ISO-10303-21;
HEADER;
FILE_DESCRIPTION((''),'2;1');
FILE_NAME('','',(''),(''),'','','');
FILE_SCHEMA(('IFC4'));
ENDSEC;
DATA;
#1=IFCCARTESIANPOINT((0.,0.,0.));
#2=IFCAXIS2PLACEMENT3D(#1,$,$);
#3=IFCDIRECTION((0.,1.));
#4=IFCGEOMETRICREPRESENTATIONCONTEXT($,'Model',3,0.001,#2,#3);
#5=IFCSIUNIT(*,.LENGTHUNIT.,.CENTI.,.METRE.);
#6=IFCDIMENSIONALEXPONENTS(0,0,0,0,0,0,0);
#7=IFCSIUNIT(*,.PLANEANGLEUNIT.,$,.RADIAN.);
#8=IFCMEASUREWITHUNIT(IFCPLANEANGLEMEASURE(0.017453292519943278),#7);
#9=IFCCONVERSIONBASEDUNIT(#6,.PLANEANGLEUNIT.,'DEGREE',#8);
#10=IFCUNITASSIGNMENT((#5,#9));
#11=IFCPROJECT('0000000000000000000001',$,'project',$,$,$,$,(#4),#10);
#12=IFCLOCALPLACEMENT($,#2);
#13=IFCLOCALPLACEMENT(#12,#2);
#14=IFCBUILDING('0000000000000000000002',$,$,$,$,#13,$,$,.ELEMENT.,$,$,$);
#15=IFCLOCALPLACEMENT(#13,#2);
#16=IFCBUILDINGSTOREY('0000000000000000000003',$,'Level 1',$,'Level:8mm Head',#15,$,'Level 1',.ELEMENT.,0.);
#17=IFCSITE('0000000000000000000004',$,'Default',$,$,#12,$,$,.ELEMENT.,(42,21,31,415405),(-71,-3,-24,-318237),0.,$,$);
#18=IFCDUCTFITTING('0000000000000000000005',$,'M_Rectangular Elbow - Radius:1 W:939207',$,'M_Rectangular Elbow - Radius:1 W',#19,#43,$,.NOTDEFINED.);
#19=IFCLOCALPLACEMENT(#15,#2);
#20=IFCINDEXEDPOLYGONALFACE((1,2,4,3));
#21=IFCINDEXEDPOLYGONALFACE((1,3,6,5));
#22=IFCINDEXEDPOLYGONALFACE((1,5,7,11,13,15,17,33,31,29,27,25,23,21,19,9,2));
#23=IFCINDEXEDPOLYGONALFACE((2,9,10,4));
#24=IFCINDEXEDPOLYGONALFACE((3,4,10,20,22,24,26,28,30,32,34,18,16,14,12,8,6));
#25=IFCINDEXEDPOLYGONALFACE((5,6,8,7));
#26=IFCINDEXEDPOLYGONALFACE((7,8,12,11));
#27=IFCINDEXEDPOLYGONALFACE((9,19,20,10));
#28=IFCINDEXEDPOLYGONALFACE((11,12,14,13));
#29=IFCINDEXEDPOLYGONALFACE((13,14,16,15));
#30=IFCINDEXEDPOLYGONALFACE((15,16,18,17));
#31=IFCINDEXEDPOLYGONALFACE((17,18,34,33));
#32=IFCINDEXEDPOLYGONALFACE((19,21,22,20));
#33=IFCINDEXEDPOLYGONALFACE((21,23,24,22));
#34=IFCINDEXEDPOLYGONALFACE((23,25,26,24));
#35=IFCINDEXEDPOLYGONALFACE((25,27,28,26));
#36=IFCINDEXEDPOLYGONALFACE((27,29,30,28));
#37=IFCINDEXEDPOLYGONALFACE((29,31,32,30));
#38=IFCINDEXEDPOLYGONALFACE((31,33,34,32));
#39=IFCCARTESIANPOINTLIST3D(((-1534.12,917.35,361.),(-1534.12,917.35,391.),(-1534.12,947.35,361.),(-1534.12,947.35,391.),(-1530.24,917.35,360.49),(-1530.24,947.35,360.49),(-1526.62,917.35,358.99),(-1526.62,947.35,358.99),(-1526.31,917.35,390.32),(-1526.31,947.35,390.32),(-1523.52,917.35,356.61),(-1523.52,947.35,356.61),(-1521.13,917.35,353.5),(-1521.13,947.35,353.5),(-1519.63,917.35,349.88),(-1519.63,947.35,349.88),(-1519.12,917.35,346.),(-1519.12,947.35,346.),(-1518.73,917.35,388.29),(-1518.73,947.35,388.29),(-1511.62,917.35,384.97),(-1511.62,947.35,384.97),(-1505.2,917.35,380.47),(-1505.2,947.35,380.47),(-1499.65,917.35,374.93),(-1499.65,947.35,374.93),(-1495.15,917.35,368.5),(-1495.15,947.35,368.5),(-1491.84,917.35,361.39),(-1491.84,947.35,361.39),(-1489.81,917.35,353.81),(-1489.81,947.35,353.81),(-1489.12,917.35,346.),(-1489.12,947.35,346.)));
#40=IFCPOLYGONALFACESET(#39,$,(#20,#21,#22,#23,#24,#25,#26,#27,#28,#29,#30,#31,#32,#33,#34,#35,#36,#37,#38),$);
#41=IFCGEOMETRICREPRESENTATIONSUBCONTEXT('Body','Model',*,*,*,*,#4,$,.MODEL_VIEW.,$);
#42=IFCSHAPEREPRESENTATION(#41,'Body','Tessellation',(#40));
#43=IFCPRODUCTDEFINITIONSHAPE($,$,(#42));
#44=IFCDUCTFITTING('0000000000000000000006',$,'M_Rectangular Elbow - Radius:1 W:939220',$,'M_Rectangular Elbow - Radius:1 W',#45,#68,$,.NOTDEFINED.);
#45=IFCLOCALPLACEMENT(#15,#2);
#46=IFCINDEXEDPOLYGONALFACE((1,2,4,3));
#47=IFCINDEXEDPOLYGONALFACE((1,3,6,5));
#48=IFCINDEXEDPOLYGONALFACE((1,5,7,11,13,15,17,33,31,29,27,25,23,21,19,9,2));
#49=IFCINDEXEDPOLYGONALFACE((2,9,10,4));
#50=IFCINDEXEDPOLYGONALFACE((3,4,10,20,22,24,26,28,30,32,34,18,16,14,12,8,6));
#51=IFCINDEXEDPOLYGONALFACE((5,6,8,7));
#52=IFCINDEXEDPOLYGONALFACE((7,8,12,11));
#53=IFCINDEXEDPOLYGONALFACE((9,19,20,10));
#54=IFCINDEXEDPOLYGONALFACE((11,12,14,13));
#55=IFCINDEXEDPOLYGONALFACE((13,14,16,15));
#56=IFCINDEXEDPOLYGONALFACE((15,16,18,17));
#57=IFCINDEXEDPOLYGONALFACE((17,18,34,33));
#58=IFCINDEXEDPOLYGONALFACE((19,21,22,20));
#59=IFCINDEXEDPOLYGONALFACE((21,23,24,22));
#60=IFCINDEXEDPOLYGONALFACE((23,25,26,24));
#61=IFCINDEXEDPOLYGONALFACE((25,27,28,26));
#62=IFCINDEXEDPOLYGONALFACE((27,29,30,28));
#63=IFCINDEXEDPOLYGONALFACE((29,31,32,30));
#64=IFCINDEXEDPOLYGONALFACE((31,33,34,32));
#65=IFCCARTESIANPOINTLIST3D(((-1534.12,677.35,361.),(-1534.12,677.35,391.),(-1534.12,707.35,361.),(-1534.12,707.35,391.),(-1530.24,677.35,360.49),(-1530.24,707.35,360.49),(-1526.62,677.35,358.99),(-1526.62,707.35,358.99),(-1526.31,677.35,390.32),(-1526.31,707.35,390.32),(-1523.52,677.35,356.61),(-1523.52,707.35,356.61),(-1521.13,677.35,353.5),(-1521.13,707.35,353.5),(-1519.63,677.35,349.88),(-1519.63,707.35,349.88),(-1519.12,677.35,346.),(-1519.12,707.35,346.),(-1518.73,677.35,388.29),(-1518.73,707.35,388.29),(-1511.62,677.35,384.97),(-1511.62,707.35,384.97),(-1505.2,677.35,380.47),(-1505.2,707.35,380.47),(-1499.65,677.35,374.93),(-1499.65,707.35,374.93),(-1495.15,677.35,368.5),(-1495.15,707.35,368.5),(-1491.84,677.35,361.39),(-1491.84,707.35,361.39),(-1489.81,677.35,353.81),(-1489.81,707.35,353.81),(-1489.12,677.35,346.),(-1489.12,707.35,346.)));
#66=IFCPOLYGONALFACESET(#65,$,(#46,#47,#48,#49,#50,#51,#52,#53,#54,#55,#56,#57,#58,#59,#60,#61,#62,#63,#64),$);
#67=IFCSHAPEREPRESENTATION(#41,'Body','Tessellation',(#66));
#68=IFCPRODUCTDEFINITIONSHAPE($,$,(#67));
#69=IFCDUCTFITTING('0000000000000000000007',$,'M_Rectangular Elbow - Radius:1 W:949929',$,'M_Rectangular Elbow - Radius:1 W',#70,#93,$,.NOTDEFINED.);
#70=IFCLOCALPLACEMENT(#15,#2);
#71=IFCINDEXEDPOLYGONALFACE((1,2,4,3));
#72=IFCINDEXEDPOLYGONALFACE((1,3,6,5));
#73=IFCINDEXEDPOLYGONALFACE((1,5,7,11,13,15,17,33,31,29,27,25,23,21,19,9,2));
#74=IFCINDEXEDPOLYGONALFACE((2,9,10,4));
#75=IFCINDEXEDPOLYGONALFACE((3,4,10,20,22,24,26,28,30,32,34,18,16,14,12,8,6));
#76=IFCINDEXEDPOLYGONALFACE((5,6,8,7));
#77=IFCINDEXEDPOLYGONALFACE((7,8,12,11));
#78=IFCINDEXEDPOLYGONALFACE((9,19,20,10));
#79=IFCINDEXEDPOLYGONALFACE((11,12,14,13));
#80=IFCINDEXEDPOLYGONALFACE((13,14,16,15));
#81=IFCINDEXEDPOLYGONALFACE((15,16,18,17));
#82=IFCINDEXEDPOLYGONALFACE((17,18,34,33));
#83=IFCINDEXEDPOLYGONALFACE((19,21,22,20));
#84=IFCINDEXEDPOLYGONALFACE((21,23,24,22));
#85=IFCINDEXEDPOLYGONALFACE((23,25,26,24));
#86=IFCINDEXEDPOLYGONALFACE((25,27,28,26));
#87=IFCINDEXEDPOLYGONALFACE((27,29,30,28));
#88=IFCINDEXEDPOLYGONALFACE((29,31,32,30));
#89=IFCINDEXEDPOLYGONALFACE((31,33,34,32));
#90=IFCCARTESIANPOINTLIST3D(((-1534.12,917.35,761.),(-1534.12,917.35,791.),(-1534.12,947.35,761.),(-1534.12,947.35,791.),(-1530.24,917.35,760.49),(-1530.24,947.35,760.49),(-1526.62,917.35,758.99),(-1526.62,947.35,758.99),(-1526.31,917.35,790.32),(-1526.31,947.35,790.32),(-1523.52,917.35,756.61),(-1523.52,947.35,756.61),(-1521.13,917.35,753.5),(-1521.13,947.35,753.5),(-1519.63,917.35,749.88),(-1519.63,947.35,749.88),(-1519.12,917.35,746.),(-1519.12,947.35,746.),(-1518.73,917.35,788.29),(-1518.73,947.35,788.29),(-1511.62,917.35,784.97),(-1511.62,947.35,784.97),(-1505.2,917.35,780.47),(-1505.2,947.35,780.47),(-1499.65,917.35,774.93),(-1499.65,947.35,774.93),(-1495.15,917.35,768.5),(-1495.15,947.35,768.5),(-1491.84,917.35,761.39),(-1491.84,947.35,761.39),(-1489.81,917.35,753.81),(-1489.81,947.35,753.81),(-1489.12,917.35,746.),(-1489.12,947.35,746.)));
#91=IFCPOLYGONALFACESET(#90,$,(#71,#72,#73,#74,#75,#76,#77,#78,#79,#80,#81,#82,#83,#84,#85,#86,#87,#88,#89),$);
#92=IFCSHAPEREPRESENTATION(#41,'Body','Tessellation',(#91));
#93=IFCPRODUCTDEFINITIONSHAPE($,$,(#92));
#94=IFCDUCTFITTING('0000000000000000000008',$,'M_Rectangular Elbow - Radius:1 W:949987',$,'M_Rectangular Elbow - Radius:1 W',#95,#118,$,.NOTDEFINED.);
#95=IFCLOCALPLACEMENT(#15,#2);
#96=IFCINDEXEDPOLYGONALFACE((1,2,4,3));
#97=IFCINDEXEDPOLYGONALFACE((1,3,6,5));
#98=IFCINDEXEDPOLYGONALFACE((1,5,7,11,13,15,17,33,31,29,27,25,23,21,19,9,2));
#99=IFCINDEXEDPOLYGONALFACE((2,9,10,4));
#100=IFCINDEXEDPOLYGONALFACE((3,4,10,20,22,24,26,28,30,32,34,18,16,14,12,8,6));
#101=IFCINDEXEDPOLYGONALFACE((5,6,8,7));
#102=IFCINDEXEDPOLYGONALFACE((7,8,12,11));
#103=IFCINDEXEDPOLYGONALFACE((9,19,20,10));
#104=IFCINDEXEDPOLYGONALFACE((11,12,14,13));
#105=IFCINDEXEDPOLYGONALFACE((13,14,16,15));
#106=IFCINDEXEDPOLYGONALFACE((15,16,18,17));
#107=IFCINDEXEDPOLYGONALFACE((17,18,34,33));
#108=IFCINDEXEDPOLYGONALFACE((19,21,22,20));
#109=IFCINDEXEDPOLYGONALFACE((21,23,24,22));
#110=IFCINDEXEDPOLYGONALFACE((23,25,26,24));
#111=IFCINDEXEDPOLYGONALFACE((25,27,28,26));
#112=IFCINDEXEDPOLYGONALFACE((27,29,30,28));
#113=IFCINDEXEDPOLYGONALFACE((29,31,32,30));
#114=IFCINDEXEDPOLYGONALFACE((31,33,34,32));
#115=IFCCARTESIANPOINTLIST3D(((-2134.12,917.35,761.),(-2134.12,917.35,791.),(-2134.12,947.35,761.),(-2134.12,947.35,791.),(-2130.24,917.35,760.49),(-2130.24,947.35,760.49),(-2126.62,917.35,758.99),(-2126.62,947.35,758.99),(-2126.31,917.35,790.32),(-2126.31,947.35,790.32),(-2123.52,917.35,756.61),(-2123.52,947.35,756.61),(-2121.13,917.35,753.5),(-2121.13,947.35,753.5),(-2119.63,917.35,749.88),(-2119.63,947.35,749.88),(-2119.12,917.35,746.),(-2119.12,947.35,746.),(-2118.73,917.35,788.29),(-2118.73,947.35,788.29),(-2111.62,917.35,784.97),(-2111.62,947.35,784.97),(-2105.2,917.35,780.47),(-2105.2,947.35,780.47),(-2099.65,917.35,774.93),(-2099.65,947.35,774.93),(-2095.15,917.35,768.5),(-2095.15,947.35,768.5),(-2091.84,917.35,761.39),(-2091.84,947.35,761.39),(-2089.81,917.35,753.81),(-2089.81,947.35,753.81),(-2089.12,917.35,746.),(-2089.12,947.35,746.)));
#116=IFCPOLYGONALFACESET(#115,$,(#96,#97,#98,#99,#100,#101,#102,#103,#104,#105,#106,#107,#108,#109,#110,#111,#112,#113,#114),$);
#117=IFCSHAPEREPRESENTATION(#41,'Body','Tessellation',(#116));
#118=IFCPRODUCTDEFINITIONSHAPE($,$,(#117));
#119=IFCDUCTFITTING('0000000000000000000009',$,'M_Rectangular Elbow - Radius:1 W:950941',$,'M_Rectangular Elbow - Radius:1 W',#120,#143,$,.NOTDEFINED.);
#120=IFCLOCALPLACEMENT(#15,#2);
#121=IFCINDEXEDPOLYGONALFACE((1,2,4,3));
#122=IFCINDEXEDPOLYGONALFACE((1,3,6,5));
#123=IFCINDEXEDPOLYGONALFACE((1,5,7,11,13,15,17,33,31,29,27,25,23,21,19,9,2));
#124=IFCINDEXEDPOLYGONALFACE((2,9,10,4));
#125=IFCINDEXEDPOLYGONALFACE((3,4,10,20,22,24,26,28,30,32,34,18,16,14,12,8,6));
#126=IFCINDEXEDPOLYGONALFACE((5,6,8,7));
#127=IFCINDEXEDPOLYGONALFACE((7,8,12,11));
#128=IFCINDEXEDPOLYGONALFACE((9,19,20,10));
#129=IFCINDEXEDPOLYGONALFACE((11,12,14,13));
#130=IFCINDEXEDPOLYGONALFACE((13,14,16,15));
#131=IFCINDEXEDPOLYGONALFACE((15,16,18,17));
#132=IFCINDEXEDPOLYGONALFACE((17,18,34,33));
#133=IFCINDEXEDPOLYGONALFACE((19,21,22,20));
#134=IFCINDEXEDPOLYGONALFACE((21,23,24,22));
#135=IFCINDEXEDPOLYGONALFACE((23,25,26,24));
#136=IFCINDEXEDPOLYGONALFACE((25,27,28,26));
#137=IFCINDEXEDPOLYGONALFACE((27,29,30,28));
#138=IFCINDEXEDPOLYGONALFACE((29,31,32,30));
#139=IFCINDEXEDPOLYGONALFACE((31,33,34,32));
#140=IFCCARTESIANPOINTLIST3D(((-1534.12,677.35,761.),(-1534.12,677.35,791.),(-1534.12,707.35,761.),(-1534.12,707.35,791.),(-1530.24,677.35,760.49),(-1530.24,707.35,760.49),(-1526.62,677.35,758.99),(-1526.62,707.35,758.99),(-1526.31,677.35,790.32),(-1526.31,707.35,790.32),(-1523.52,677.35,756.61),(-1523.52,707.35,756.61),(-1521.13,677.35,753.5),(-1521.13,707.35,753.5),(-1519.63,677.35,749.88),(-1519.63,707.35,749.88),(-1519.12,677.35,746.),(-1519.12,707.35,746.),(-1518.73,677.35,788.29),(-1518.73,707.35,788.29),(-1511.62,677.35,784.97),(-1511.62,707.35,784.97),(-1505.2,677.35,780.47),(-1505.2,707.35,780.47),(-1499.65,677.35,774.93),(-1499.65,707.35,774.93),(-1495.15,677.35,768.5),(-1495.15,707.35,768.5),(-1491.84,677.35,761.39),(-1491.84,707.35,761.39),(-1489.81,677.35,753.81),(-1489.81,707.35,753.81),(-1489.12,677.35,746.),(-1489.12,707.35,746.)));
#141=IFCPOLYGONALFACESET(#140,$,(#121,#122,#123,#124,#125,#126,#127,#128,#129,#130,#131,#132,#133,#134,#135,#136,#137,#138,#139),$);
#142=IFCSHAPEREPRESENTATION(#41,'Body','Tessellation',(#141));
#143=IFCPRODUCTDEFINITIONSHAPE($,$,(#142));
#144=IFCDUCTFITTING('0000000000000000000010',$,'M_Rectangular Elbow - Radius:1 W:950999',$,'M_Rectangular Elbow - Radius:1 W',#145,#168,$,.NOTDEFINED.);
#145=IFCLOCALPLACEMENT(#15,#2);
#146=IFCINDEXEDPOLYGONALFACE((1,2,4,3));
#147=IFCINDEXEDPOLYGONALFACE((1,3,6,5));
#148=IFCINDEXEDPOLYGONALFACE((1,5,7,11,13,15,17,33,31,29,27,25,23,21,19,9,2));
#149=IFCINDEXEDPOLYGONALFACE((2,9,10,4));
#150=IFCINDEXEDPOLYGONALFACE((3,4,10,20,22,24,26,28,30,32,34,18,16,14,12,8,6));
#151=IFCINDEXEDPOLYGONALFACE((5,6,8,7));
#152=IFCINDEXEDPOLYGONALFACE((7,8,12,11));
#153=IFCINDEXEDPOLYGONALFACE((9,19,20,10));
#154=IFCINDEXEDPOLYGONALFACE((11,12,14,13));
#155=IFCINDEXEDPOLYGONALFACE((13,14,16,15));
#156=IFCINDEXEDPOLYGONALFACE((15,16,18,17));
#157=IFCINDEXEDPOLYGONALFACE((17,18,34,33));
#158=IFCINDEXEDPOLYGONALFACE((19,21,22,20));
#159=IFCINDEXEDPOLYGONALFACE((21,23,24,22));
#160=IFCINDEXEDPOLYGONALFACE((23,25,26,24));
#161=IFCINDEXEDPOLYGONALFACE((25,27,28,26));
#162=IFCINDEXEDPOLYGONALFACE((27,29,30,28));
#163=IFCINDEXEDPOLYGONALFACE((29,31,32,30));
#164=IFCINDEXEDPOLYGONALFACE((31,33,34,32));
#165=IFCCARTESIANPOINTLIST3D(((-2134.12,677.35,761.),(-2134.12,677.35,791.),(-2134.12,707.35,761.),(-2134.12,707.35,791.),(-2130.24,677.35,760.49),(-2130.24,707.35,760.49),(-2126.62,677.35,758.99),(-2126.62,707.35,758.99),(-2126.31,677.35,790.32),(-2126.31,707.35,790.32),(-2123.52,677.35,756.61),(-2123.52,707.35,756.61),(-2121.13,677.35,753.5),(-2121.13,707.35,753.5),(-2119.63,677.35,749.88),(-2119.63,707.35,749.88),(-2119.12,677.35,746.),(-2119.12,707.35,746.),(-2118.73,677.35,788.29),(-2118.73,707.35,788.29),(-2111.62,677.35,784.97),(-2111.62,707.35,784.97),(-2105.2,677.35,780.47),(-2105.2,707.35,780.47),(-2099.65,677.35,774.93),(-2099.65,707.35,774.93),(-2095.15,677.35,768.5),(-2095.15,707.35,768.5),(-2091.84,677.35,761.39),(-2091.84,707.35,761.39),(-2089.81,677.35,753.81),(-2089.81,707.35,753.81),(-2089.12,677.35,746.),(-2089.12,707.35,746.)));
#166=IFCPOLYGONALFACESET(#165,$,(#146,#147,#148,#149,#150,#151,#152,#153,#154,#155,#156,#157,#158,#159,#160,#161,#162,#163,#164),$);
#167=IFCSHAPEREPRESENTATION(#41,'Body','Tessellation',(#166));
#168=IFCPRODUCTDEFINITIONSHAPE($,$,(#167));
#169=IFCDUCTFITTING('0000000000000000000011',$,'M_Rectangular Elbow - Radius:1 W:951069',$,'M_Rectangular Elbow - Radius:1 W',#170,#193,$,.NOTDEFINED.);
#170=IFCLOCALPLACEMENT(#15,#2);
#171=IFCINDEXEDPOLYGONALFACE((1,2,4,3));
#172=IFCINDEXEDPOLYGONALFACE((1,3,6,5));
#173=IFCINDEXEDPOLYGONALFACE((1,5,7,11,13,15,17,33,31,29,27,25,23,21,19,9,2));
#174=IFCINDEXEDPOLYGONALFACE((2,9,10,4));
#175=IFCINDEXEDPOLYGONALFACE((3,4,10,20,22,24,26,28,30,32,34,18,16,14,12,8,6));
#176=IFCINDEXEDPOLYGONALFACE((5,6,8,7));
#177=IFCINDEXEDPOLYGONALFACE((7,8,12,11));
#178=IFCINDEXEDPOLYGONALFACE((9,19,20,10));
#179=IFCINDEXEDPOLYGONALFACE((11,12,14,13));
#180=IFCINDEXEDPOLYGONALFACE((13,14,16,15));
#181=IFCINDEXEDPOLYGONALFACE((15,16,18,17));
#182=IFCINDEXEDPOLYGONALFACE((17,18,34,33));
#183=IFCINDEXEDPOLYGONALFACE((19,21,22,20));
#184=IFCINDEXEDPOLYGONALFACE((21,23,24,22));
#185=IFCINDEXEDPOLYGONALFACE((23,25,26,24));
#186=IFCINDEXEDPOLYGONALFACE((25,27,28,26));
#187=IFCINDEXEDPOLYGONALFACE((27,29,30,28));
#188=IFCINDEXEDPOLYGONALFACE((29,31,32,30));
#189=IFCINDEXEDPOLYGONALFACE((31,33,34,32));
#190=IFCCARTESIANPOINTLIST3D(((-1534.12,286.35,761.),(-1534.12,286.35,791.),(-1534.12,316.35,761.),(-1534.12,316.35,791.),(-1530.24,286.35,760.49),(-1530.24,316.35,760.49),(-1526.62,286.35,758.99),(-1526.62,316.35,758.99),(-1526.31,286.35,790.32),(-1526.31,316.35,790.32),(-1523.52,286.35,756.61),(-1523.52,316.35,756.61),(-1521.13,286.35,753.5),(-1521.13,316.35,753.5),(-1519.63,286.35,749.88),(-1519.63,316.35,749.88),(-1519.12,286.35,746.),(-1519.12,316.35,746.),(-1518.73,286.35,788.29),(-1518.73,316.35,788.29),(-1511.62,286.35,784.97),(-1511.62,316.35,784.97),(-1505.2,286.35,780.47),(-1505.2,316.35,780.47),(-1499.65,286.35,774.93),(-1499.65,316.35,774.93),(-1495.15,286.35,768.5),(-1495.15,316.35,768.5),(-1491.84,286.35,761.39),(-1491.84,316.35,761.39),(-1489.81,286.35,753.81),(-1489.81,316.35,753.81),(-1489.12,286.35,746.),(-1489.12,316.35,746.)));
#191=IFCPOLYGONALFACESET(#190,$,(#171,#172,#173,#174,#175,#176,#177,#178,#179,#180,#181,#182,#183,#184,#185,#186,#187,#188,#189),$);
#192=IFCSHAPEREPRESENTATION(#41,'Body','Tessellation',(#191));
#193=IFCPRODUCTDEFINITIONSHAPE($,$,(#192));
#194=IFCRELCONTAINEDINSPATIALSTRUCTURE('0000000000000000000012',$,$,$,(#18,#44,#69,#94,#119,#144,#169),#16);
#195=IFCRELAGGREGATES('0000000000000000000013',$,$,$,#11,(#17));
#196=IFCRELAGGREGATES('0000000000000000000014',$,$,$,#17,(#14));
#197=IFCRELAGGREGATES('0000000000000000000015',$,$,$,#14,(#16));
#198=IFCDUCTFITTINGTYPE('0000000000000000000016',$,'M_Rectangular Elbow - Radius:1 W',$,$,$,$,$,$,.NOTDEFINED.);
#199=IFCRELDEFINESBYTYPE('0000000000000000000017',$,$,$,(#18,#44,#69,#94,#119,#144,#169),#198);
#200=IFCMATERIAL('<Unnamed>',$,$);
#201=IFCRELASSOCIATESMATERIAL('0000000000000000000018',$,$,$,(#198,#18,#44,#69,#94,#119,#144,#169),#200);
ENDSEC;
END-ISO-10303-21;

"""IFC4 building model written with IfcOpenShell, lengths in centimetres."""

from ifc_helpers import new_model, entity, si_unit, converted_unit, direction, frame, origin, place, context, subcontext, project, spatial, line, arc, indexed_curve, outline, extrude, source, transform, mapped, material, type_object, type_shapes, element, save


model = new_model("IFC4")

# Units and contexts
model_context = context("Model", 3, precision=0.001, world=origin(), true_north=direction((0.0, 1.0)))
body_context = subcontext(model_context, "Body", "Model", "MODEL_VIEW")
ifc_project = project(units=[si_unit("LENGTHUNIT", "METRE", prefix="CENTI"), converted_unit("PLANEANGLEUNIT", "DEGREE", entity("IfcPlaneAngleMeasure", 0.017453292519943278), si_unit("PLANEANGLEUNIT", "RADIAN"), dimensions=[0, 0, 0, 0, 0, 0, 0])], contexts=[model_context])

# Site, building, storey
site_placement = place(None, origin())
site = spatial("IfcSite", under=ifc_project, at=site_placement, Name="Default", CompositionType="ELEMENT", RefLatitude=(42, 21, 31, 415405), RefLongitude=(-71, -3, -24, -318237), RefElevation=0.0)
building_placement = place(site_placement, origin())
building = spatial("IfcBuilding", under=site, at=building_placement, CompositionType="ELEMENT")
storey_placement = place(building_placement, origin())
storey = spatial("IfcBuildingStorey", under=building, at=storey_placement, Name="Level 1", ObjectType="Level:8mm Head", LongName="Level 1", CompositionType="ELEMENT", Elevation=0.0)

# Duct fittings
ifc_material = material(Name="<Unnamed>")
duct_fitting_type_1 = type_object("IfcDuctFittingType", Name="M_Rectangular Elbow - Radius:1 W", PredefinedType="NOTDEFINED", material=ifc_material)
shared_shape_1 = source(origin(), body_context, "Body", "SweptSolid", [
    extrude(outline(indexed_curve([(-30.0, -15.0), (0.0, -15.0), (4.39, -4.39), (15.0, 0.0), (15.0, 30.0), (-16.82, 16.82)], segments=[line(1, 2), arc(2, 3, 4), line(4, 5), arc(5, 6, 1)], self_intersect=False)), frame((-15.0, 15.0, -15.0), z_axis=(0.0, 0.0, 1.0), x_axis=(-1.0, 0.0, 0.0)), (0.0, 0.0, 1.0), 30.0),
])
type_shapes(duct_fitting_type_1, [shared_shape_1])
for number, where, z_axis, x_axis, name in (
    (1, (-1504.12, 932.35, 376.0), (0.0, -1.0, 0.0), (0.0, 0.0, 1.0), "M_Rectangular Elbow - Radius:1 W:939207"),
    (2, (-1504.12, 692.35, 376.0), (0.0, -1.0, 0.0), (0.0, 0.0, 1.0), "M_Rectangular Elbow - Radius:1 W:939220"),
    (3, (-1504.12, 932.35, 776.0), (0.0, 1.0, 0.0), (1.0, 0.0, 0.0), "M_Rectangular Elbow - Radius:1 W:949929"),
    (4, (-2104.12, 932.35, 776.0), (0.0, 1.0, 0.0), (1.0, 0.0, 0.0), "M_Rectangular Elbow - Radius:1 W:949987"),
    (5, (-1504.12, 692.35, 776.0), (0.0, 1.0, 0.0), (1.0, 0.0, 0.0), "M_Rectangular Elbow - Radius:1 W:950941"),
    (6, (-2104.12, 692.35, 776.0), (0.0, 1.0, 0.0), (1.0, 0.0, 0.0), "M_Rectangular Elbow - Radius:1 W:950999"),
    (7, (-1504.12, 301.35, 776.0), (0.0, 1.0, 0.0), (1.0, 0.0, 0.0), "M_Rectangular Elbow - Radius:1 W:951069"),
):
    element("IfcDuctFitting", number, at=place(storey_placement, frame(where, z_axis=z_axis, x_axis=x_axis)), inside=storey, type_object=duct_fitting_type_1, material=ifc_material, Name=name, ObjectType="M_Rectangular Elbow - Radius:1 W", PredefinedType="NOTDEFINED", context=body_context, shape_type="MappedRepresentation", body=[
        mapped(shared_shape_1, transform((0.0, 0.0, 0.0), scale=1.0)),
    ])

save(model, "model.ifc")
